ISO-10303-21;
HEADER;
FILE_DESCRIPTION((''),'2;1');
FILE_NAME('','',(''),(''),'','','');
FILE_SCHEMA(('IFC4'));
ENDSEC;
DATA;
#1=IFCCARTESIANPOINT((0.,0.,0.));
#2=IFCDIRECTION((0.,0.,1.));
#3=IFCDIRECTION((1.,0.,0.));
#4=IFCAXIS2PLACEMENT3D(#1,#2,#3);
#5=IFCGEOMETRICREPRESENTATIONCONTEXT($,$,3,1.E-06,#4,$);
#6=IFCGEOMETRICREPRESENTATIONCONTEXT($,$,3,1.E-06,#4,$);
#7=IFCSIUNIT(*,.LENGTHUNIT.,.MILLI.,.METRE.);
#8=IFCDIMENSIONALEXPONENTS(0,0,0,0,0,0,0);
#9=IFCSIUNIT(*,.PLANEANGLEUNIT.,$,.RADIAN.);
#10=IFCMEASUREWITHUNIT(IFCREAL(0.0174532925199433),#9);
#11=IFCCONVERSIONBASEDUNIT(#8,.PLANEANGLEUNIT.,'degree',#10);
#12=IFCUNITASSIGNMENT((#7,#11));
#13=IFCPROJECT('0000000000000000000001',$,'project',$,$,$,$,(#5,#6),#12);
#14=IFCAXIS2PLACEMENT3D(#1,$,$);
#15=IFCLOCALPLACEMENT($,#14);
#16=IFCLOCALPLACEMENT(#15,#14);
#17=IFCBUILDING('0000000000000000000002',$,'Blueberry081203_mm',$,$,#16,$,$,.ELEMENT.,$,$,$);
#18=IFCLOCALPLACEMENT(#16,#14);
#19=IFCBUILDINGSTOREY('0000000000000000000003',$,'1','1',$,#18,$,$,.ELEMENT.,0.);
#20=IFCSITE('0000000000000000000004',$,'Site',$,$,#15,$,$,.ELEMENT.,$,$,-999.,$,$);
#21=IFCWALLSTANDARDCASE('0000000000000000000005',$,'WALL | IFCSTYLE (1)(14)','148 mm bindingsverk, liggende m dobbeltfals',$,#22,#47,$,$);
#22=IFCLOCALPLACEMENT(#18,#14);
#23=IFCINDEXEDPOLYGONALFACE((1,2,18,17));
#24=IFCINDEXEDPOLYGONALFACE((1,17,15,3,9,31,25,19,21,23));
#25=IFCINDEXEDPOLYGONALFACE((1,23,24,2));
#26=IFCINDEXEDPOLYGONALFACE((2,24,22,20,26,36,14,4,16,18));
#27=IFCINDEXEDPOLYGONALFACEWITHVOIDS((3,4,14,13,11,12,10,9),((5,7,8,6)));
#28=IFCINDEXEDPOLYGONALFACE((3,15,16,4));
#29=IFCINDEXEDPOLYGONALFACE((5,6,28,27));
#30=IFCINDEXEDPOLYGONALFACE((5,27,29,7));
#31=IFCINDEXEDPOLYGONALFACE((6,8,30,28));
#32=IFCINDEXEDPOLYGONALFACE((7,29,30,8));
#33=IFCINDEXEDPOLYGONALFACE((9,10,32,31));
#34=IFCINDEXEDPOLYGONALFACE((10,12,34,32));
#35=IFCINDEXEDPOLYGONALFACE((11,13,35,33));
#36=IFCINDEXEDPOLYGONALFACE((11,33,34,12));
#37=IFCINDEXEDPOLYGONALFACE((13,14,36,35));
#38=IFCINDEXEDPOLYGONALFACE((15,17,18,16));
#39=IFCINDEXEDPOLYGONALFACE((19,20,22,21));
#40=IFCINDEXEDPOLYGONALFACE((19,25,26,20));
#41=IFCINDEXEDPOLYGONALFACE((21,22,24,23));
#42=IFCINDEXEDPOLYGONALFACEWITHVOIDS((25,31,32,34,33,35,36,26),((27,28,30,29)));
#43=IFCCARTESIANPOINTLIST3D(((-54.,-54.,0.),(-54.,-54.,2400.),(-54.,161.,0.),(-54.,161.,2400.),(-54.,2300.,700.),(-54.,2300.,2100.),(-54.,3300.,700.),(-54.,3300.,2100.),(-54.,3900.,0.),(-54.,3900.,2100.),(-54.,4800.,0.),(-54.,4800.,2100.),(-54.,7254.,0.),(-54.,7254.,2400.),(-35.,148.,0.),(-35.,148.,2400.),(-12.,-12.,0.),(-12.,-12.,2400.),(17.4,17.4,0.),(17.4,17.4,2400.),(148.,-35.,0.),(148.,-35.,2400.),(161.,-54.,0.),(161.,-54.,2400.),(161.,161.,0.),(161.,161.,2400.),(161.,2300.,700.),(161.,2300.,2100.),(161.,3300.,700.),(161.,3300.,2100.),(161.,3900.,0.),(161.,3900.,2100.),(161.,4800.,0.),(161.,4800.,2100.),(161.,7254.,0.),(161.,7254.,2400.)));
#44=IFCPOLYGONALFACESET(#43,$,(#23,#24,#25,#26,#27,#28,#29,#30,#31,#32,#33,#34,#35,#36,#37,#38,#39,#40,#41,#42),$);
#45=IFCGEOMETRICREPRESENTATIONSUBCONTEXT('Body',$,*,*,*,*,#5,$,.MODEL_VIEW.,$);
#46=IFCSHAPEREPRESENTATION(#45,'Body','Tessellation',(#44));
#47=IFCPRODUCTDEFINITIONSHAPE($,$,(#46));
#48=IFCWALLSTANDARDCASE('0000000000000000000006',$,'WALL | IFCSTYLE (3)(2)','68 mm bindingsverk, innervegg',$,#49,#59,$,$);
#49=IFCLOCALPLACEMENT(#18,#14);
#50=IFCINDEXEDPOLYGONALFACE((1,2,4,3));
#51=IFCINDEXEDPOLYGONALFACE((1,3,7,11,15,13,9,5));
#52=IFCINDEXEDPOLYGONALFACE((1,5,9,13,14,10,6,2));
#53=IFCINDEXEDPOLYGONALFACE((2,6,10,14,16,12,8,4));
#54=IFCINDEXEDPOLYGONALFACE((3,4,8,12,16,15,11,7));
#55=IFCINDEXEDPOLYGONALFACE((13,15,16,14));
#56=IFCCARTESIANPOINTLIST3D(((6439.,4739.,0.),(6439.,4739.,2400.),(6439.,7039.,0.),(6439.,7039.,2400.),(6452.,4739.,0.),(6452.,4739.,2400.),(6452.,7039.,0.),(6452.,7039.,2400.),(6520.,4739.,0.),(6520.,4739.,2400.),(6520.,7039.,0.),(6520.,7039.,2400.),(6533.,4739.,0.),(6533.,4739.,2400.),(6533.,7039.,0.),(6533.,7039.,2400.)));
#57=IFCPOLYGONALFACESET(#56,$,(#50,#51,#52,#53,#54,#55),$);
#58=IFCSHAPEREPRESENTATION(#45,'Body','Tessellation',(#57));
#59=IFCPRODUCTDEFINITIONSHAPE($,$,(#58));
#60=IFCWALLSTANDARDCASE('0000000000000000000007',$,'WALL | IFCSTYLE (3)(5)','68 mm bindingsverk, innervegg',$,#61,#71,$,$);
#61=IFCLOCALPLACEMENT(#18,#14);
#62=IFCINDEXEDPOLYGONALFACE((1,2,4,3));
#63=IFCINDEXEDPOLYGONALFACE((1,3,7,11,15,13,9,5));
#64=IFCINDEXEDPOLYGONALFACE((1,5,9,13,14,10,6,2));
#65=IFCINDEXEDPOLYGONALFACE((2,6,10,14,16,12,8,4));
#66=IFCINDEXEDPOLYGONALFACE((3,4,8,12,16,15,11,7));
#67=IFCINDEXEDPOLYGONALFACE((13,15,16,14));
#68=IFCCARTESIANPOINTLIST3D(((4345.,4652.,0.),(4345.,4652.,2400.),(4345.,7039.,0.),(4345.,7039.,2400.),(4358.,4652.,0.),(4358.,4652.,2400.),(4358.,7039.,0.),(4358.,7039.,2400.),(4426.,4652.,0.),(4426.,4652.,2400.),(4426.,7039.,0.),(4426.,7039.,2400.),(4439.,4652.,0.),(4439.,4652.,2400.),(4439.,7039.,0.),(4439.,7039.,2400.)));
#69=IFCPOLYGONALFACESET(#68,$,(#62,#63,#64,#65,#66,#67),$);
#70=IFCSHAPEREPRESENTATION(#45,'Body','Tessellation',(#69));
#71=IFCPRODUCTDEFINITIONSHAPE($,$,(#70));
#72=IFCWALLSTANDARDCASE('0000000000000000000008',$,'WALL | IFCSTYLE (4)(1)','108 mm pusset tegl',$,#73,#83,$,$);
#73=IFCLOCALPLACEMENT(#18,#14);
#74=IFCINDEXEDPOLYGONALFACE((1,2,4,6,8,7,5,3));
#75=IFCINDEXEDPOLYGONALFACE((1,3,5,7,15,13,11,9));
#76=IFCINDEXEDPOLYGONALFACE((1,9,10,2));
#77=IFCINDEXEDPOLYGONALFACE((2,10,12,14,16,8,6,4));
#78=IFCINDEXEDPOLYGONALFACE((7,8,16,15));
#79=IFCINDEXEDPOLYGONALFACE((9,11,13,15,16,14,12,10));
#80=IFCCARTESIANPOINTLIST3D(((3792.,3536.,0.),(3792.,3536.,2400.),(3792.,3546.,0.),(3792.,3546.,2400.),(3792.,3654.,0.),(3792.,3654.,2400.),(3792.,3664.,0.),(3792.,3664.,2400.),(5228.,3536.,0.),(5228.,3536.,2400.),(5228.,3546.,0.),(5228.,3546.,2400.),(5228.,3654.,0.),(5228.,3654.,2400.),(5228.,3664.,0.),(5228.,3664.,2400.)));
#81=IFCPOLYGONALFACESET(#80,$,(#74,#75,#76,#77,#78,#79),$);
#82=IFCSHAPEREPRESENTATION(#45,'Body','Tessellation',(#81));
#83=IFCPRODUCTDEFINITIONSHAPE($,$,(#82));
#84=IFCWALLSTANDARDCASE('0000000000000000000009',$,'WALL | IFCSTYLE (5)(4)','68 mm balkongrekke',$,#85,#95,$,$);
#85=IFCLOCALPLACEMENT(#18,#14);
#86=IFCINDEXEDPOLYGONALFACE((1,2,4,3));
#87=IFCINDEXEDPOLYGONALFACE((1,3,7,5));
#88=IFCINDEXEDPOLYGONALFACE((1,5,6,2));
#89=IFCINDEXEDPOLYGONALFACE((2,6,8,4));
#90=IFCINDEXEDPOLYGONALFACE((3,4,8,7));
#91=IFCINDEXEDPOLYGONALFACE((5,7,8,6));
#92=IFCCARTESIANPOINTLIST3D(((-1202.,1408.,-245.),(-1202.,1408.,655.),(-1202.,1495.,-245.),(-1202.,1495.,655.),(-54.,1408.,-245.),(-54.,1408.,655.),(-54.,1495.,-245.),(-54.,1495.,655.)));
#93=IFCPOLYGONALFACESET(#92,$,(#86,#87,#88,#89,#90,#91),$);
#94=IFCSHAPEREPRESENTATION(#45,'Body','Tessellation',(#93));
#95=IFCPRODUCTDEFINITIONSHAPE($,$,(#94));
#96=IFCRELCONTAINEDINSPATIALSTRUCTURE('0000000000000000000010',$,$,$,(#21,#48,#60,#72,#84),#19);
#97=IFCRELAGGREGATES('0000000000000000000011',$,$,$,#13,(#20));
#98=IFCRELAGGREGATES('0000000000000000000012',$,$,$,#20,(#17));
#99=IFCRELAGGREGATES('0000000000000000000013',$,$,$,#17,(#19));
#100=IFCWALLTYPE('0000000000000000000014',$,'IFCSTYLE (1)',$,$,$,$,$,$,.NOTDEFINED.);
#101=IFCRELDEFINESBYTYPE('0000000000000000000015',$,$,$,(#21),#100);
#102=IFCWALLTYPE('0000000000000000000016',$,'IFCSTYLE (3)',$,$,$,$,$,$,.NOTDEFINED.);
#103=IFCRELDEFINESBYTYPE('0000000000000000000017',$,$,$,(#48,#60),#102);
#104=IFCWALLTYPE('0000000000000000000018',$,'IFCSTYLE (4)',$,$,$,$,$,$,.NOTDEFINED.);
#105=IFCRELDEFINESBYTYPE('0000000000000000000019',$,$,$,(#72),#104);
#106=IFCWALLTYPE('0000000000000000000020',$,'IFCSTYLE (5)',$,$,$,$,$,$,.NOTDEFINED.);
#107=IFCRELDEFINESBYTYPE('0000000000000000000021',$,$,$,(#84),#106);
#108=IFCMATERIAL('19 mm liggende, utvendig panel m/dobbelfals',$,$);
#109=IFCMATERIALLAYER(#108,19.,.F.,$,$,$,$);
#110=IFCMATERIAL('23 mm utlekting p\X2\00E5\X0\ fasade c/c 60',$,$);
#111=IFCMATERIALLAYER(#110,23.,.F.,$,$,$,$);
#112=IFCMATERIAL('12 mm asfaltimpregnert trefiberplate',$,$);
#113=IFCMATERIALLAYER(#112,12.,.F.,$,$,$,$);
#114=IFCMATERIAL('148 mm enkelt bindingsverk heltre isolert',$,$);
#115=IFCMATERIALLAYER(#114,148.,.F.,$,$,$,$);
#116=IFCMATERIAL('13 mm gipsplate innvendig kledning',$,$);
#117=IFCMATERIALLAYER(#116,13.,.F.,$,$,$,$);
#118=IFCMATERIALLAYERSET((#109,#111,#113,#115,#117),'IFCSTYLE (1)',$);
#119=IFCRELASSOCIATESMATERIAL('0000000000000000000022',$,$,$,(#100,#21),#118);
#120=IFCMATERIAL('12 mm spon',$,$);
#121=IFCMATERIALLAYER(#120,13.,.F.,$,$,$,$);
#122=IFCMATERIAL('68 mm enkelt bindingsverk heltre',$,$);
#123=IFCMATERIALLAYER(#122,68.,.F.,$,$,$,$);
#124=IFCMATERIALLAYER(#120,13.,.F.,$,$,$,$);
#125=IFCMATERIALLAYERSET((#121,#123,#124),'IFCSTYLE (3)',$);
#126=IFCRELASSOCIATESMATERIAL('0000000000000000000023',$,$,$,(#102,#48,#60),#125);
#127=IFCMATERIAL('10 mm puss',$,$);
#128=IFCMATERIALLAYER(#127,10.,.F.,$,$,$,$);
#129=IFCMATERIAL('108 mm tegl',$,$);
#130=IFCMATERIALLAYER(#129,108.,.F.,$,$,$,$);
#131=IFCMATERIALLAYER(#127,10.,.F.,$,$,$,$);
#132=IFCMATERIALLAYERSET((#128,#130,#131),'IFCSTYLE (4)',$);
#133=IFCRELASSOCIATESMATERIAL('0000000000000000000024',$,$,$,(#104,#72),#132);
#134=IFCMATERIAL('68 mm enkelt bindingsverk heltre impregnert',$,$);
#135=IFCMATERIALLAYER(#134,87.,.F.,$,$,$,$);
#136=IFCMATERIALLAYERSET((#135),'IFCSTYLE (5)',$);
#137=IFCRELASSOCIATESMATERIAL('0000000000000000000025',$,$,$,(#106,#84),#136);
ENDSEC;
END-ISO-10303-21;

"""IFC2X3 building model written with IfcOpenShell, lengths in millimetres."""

from ifc_helpers import new_model, entity, si_unit, converted_unit, frame, frame_2d, origin, origin_with_axes, origin_2d_with_axis, place, context, subcontext, project, spatial, polyline, segment, composite_curve, rectangle, outline, extrude, material, layer, layer_set, layer_usage, type_object, element, save


model = new_model("IFC2X3")

# Units and contexts
context_of_model_1 = context(None, 3, precision=1e-06, world=origin_with_axes())
context_of_model_2 = context(None, 3, precision=1e-06, world=origin_with_axes())
body_context = subcontext(context_of_model_1, "Body", None, "MODEL_VIEW")
ifc_project = project(units=[si_unit("LENGTHUNIT", "METRE", prefix="MILLI"), converted_unit("PLANEANGLEUNIT", "degree", entity("IfcReal", 0.0174532925199433), si_unit("PLANEANGLEUNIT", "RADIAN"), dimensions=[0, 0, 0, 0, 0, 0, 0])], contexts=[context_of_model_1, context_of_model_2])

# Site, building, storey
site_placement = place(None, origin())
site = spatial("IfcSite", under=ifc_project, at=site_placement, Name="Site", CompositionType="ELEMENT", RefElevation=-999.0)
building_placement = place(site_placement, origin())
building = spatial("IfcBuilding", under=site, at=building_placement, Name="Blueberry081203_mm", CompositionType="ELEMENT")
storey_placement = place(building_placement, origin())
storey = spatial("IfcBuildingStorey", under=building, at=storey_placement, Name="1", Description="1", CompositionType="ELEMENT", Elevation=0.0)

# Shared definitions
ifc_material_1 = material(Name="19 mm liggende, utvendig panel m/dobbelfals")
ifc_layer_1 = layer(ifc_material_1, 19.0, ventilated=False)
ifc_material_2 = material(Name="23 mm utlekting på fasade c/c 60")
ifc_layer_2 = layer(ifc_material_2, 23.0, ventilated=False)
ifc_material_3 = material(Name="12 mm asfaltimpregnert trefiberplate")
ifc_layer_3 = layer(ifc_material_3, 12.0, ventilated=False)
ifc_material_4 = material(Name="148 mm enkelt bindingsverk heltre isolert")
ifc_layer_4 = layer(ifc_material_4, 148.0, ventilated=False)
ifc_material_5 = material(Name="13 mm gipsplate innvendig kledning")
ifc_layer_5 = layer(ifc_material_5, 13.0, ventilated=False)
ifc_layer_set_1 = layer_set([ifc_layer_1, ifc_layer_2, ifc_layer_3, ifc_layer_4, ifc_layer_5], Name="IFCSTYLE (1)")
wall_type_1 = type_object("IfcWallType", Name="IFCSTYLE (1)", PredefinedType="NOTDEFINED", material=ifc_layer_set_1)

# Wall, openings
ifc_layer_usage_1 = layer_usage(ifc_layer_set_1, "AXIS2", "POSITIVE", 0.0)
wall_1_placement = place(storey_placement, frame((-54.0, 7254.0, 0.0), z_axis=(0.0, 0.0, 1.0), x_axis=(0.0, -1.0, 0.0)))
wall_1 = element("IfcWallStandardCase", 1, at=wall_1_placement, inside=storey, type_object=wall_type_1, material=ifc_layer_usage_1, Name="WALL | IFCSTYLE (1)(14)", Description="148 mm bindingsverk, liggende m dobbeltfals", context=body_context, shape_type="SweptSolid", held_by="IfcProductRepresentation", body=[
    extrude(outline(composite_curve([segment(polyline([(7289.0, 19.0), (7308.0, 0.0)]), True, "CONTINUOUS"), segment(polyline([(7308.0, 0.0), (7308.0, 0.0)]), True, "CONTINUOUS"), segment(polyline([(7308.0, 0.0), (7308.0, 19.0)]), True, "CONTINUOUS"), segment(polyline([(7308.0, 19.0), (7308.0, 42.0)]), True, "CONTINUOUS"), segment(polyline([(7308.0, 42.0), (7308.0, 54.0)]), True, "CONTINUOUS"), segment(polyline([(7308.0, 54.0), (7308.0, 202.0)]), True, "CONTINUOUS"), segment(polyline([(7308.0, 202.0), (7308.0, 215.0)]), True, "CONTINUOUS"), segment(polyline([(7308.0, 215.0), (7308.0, 215.0)]), True, "CONTINUOUS"), segment(polyline([(7308.0, 215.0), (7289.0, 202.0)]), True, "CONTINUOUS"), segment(polyline([(7289.0, 202.0), (7236.6, 71.4)]), True, "CONTINUOUS"), segment(polyline([(7236.6, 71.4), (7106.0, 202.0)]), True, "CONTINUOUS"), segment(polyline([(7106.0, 202.0), (7093.0, 215.0)]), True, "CONTINUOUS"), segment(polyline([(7093.0, 215.0), (1462.0, 215.0)]), True, "CONTINUOUS"), segment(polyline([(1462.0, 215.0), (0.0, 215.0)]), True, "CONTINUOUS"), segment(polyline([(0.0, 215.0), (0.0, 202.0)]), True, "CONTINUOUS"), segment(polyline([(0.0, 202.0), (0.0, 54.0)]), True, "CONTINUOUS"), segment(polyline([(0.0, 54.0), (0.0, 42.0)]), True, "CONTINUOUS"), segment(polyline([(0.0, 42.0), (0.0, 19.0)]), True, "CONTINUOUS"), segment(polyline([(0.0, 19.0), (0.0, 0.0)]), True, "CONTINUOUS"), segment(polyline([(0.0, 0.0), (1462.0, 0.0)]), True, "CONTINUOUS"), segment(polyline([(1462.0, 0.0), (7093.0, 0.0)]), True, "CONTINUOUS"), segment(polyline([(7093.0, 0.0), (7106.0, 19.0)]), True, "CONTINUOUS"), segment(polyline([(7106.0, 19.0), (7266.0, 42.0)]), True, "CONTINUOUS"), segment(polyline([(7266.0, 42.0), (7289.0, 19.0)]), True, "CONTINUOUS")], self_intersect=False)), origin(), (0.0, 0.0, 1.0), 2400.0),
])
opening_1_placement = place(wall_1_placement, frame((3954.0, 107.5, 700.0)))
element("IfcOpeningElement", 2, at=opening_1_placement, cuts=wall_1, context=body_context, shape_type="SweptSolid", held_by="IfcProductRepresentation", body=[
    extrude(rectangle(XDim=1000.0, YDim=1400.0, at=origin_2d_with_axis()), frame((500.0, 107.5, 700.0), z_axis=(0.0, -1.0, 0.0), x_axis=(1.0, 0.0, 0.0)), (0.0, 0.0, 1.0), 215.0),
])
opening_2_placement = place(wall_1_placement, frame((2454.0, 107.5, 0.0)))
element("IfcOpeningElement", 3, at=opening_2_placement, cuts=wall_1, context=body_context, shape_type="SweptSolid", held_by="IfcProductRepresentation", body=[
    extrude(rectangle(XDim=900.0, YDim=2100.0, at=origin_2d_with_axis()), frame((450.0, 107.5, 1050.0), z_axis=(0.0, -1.0, 0.0), x_axis=(1.0, 0.0, 0.0)), (0.0, 0.0, 1.0), 215.0),
])

# Walls
ifc_material_6 = material(Name="12 mm spon")
ifc_layer_6 = layer(ifc_material_6, 13.0, ventilated=False)
ifc_material_7 = material(Name="68 mm enkelt bindingsverk heltre")
ifc_layer_7 = layer(ifc_material_7, 68.0, ventilated=False)
ifc_layer_8 = layer(ifc_material_6, 13.0, ventilated=False)
ifc_layer_set_2 = layer_set([ifc_layer_6, ifc_layer_7, ifc_layer_8], Name="IFCSTYLE (3)")
ifc_layer_usage_2 = layer_usage(ifc_layer_set_2, "AXIS2", "POSITIVE", 0.0)
wall_type_2 = type_object("IfcWallType", Name="IFCSTYLE (3)", PredefinedType="NOTDEFINED", material=ifc_layer_set_2)
wall_2_placement = place(storey_placement, frame((6439.0, 7039.0, 0.0), z_axis=(0.0, 0.0, 1.0), x_axis=(0.0, -1.0, 0.0)))
element("IfcWallStandardCase", 4, at=wall_2_placement, inside=storey, type_object=wall_type_2, material=ifc_layer_usage_2, Name="WALL | IFCSTYLE (3)(2)", Description="68 mm bindingsverk, innervegg", context=body_context, shape_type="SweptSolid", held_by="IfcProductRepresentation", body=[
    extrude(outline(composite_curve([segment(polyline([(0.0, 13.0), (0.0, 0.0)]), True, "CONTINUOUS"), segment(polyline([(0.0, 0.0), (2300.0, 0.0)]), True, "CONTINUOUS"), segment(polyline([(2300.0, 0.0), (2300.0, 13.0)]), True, "CONTINUOUS"), segment(polyline([(2300.0, 13.0), (2300.0, 81.0)]), True, "CONTINUOUS"), segment(polyline([(2300.0, 81.0), (2300.0, 94.0)]), True, "CONTINUOUS"), segment(polyline([(2300.0, 94.0), (0.0, 94.0)]), True, "CONTINUOUS"), segment(polyline([(0.0, 94.0), (0.0, 81.0)]), True, "CONTINUOUS"), segment(polyline([(0.0, 81.0), (0.0, 13.0)]), True, "CONTINUOUS")], self_intersect=False)), origin(), (0.0, 0.0, 1.0), 2400.0),
])
ifc_layer_usage_3 = layer_usage(ifc_layer_set_2, "AXIS2", "POSITIVE", 0.0)
wall_3_placement = place(storey_placement, frame((4345.0, 7039.0, 0.0), z_axis=(0.0, 0.0, 1.0), x_axis=(0.0, -1.0, 0.0)))
element("IfcWallStandardCase", 5, at=wall_3_placement, inside=storey, type_object=wall_type_2, material=ifc_layer_usage_3, Name="WALL | IFCSTYLE (3)(5)", Description="68 mm bindingsverk, innervegg", context=body_context, shape_type="SweptSolid", held_by="IfcProductRepresentation", body=[
    extrude(outline(composite_curve([segment(polyline([(0.0, 13.0), (0.0, 0.0)]), True, "CONTINUOUS"), segment(polyline([(0.0, 0.0), (2387.0, 0.0)]), True, "CONTINUOUS"), segment(polyline([(2387.0, 0.0), (2387.0, 13.0)]), True, "CONTINUOUS"), segment(polyline([(2387.0, 13.0), (2387.0, 81.0)]), True, "CONTINUOUS"), segment(polyline([(2387.0, 81.0), (2387.0, 94.0)]), True, "CONTINUOUS"), segment(polyline([(2387.0, 94.0), (0.0, 94.0)]), True, "CONTINUOUS"), segment(polyline([(0.0, 94.0), (0.0, 81.0)]), True, "CONTINUOUS"), segment(polyline([(0.0, 81.0), (0.0, 13.0)]), True, "CONTINUOUS")], self_intersect=False)), origin(), (0.0, 0.0, 1.0), 2400.0),
])
ifc_material_8 = material(Name="10 mm puss")
ifc_layer_9 = layer(ifc_material_8, 10.0, ventilated=False)
ifc_material_9 = material(Name="108 mm tegl")
ifc_layer_10 = layer(ifc_material_9, 108.0, ventilated=False)
ifc_layer_11 = layer(ifc_material_8, 10.0, ventilated=False)
ifc_layer_set_3 = layer_set([ifc_layer_9, ifc_layer_10, ifc_layer_11], Name="IFCSTYLE (4)")
ifc_layer_usage_4 = layer_usage(ifc_layer_set_3, "AXIS2", "POSITIVE", 0.0)
wall_type_3 = type_object("IfcWallType", Name="IFCSTYLE (4)", PredefinedType="NOTDEFINED", material=ifc_layer_set_3)
wall_4_placement = place(storey_placement, frame((5228.0, 3664.0, 0.0), z_axis=(0.0, 0.0, 1.0), x_axis=(-1.0, 0.0, 0.0)))
element("IfcWallStandardCase", 6, at=wall_4_placement, inside=storey, type_object=wall_type_3, material=ifc_layer_usage_4, Name="WALL | IFCSTYLE (4)(1)", Description="108 mm pusset tegl", context=body_context, shape_type="SweptSolid", held_by="IfcProductRepresentation", body=[
    extrude(outline(composite_curve([segment(polyline([(0.0, 10.0), (0.0, 0.0)]), True, "CONTINUOUS"), segment(polyline([(0.0, 0.0), (1436.0, 0.0)]), True, "CONTINUOUS"), segment(polyline([(1436.0, 0.0), (1436.0, 10.0)]), True, "CONTINUOUS"), segment(polyline([(1436.0, 10.0), (1436.0, 118.0)]), True, "CONTINUOUS"), segment(polyline([(1436.0, 118.0), (1436.0, 128.0)]), True, "CONTINUOUS"), segment(polyline([(1436.0, 128.0), (0.0, 128.0)]), True, "CONTINUOUS"), segment(polyline([(0.0, 128.0), (0.0, 118.0)]), True, "CONTINUOUS"), segment(polyline([(0.0, 118.0), (0.0, 10.0)]), True, "CONTINUOUS")], self_intersect=False)), origin(), (0.0, 0.0, 1.0), 2400.0),
])
ifc_material_10 = material(Name="68 mm enkelt bindingsverk heltre impregnert")
ifc_layer_12 = layer(ifc_material_10, 87.0, ventilated=False)
ifc_layer_set_4 = layer_set([ifc_layer_12], Name="IFCSTYLE (5)")
wall_type_4 = type_object("IfcWallType", Name="IFCSTYLE (5)", PredefinedType="NOTDEFINED", material=ifc_layer_set_4)
ifc_layer_usage_5 = layer_usage(ifc_layer_set_4, "AXIS2", "POSITIVE", 0.0)
wall_5_placement = place(storey_placement, frame((-1202.0, 1408.0, -245.0)))
element("IfcWallStandardCase", 7, at=wall_5_placement, inside=storey, type_object=wall_type_4, material=ifc_layer_usage_5, Name="WALL | IFCSTYLE (5)(4)", Description="68 mm balkongrekke", context=body_context, shape_type="SweptSolid", held_by="IfcProductRepresentation", body=[
    extrude(rectangle(XDim=87.0, YDim=1148.0, at=frame_2d((574.0, 43.5), x_axis=(0.0, -1.0))), origin(), (0.0, 0.0, 1.0), 900.0),
])

save(model, "model.ifc")
